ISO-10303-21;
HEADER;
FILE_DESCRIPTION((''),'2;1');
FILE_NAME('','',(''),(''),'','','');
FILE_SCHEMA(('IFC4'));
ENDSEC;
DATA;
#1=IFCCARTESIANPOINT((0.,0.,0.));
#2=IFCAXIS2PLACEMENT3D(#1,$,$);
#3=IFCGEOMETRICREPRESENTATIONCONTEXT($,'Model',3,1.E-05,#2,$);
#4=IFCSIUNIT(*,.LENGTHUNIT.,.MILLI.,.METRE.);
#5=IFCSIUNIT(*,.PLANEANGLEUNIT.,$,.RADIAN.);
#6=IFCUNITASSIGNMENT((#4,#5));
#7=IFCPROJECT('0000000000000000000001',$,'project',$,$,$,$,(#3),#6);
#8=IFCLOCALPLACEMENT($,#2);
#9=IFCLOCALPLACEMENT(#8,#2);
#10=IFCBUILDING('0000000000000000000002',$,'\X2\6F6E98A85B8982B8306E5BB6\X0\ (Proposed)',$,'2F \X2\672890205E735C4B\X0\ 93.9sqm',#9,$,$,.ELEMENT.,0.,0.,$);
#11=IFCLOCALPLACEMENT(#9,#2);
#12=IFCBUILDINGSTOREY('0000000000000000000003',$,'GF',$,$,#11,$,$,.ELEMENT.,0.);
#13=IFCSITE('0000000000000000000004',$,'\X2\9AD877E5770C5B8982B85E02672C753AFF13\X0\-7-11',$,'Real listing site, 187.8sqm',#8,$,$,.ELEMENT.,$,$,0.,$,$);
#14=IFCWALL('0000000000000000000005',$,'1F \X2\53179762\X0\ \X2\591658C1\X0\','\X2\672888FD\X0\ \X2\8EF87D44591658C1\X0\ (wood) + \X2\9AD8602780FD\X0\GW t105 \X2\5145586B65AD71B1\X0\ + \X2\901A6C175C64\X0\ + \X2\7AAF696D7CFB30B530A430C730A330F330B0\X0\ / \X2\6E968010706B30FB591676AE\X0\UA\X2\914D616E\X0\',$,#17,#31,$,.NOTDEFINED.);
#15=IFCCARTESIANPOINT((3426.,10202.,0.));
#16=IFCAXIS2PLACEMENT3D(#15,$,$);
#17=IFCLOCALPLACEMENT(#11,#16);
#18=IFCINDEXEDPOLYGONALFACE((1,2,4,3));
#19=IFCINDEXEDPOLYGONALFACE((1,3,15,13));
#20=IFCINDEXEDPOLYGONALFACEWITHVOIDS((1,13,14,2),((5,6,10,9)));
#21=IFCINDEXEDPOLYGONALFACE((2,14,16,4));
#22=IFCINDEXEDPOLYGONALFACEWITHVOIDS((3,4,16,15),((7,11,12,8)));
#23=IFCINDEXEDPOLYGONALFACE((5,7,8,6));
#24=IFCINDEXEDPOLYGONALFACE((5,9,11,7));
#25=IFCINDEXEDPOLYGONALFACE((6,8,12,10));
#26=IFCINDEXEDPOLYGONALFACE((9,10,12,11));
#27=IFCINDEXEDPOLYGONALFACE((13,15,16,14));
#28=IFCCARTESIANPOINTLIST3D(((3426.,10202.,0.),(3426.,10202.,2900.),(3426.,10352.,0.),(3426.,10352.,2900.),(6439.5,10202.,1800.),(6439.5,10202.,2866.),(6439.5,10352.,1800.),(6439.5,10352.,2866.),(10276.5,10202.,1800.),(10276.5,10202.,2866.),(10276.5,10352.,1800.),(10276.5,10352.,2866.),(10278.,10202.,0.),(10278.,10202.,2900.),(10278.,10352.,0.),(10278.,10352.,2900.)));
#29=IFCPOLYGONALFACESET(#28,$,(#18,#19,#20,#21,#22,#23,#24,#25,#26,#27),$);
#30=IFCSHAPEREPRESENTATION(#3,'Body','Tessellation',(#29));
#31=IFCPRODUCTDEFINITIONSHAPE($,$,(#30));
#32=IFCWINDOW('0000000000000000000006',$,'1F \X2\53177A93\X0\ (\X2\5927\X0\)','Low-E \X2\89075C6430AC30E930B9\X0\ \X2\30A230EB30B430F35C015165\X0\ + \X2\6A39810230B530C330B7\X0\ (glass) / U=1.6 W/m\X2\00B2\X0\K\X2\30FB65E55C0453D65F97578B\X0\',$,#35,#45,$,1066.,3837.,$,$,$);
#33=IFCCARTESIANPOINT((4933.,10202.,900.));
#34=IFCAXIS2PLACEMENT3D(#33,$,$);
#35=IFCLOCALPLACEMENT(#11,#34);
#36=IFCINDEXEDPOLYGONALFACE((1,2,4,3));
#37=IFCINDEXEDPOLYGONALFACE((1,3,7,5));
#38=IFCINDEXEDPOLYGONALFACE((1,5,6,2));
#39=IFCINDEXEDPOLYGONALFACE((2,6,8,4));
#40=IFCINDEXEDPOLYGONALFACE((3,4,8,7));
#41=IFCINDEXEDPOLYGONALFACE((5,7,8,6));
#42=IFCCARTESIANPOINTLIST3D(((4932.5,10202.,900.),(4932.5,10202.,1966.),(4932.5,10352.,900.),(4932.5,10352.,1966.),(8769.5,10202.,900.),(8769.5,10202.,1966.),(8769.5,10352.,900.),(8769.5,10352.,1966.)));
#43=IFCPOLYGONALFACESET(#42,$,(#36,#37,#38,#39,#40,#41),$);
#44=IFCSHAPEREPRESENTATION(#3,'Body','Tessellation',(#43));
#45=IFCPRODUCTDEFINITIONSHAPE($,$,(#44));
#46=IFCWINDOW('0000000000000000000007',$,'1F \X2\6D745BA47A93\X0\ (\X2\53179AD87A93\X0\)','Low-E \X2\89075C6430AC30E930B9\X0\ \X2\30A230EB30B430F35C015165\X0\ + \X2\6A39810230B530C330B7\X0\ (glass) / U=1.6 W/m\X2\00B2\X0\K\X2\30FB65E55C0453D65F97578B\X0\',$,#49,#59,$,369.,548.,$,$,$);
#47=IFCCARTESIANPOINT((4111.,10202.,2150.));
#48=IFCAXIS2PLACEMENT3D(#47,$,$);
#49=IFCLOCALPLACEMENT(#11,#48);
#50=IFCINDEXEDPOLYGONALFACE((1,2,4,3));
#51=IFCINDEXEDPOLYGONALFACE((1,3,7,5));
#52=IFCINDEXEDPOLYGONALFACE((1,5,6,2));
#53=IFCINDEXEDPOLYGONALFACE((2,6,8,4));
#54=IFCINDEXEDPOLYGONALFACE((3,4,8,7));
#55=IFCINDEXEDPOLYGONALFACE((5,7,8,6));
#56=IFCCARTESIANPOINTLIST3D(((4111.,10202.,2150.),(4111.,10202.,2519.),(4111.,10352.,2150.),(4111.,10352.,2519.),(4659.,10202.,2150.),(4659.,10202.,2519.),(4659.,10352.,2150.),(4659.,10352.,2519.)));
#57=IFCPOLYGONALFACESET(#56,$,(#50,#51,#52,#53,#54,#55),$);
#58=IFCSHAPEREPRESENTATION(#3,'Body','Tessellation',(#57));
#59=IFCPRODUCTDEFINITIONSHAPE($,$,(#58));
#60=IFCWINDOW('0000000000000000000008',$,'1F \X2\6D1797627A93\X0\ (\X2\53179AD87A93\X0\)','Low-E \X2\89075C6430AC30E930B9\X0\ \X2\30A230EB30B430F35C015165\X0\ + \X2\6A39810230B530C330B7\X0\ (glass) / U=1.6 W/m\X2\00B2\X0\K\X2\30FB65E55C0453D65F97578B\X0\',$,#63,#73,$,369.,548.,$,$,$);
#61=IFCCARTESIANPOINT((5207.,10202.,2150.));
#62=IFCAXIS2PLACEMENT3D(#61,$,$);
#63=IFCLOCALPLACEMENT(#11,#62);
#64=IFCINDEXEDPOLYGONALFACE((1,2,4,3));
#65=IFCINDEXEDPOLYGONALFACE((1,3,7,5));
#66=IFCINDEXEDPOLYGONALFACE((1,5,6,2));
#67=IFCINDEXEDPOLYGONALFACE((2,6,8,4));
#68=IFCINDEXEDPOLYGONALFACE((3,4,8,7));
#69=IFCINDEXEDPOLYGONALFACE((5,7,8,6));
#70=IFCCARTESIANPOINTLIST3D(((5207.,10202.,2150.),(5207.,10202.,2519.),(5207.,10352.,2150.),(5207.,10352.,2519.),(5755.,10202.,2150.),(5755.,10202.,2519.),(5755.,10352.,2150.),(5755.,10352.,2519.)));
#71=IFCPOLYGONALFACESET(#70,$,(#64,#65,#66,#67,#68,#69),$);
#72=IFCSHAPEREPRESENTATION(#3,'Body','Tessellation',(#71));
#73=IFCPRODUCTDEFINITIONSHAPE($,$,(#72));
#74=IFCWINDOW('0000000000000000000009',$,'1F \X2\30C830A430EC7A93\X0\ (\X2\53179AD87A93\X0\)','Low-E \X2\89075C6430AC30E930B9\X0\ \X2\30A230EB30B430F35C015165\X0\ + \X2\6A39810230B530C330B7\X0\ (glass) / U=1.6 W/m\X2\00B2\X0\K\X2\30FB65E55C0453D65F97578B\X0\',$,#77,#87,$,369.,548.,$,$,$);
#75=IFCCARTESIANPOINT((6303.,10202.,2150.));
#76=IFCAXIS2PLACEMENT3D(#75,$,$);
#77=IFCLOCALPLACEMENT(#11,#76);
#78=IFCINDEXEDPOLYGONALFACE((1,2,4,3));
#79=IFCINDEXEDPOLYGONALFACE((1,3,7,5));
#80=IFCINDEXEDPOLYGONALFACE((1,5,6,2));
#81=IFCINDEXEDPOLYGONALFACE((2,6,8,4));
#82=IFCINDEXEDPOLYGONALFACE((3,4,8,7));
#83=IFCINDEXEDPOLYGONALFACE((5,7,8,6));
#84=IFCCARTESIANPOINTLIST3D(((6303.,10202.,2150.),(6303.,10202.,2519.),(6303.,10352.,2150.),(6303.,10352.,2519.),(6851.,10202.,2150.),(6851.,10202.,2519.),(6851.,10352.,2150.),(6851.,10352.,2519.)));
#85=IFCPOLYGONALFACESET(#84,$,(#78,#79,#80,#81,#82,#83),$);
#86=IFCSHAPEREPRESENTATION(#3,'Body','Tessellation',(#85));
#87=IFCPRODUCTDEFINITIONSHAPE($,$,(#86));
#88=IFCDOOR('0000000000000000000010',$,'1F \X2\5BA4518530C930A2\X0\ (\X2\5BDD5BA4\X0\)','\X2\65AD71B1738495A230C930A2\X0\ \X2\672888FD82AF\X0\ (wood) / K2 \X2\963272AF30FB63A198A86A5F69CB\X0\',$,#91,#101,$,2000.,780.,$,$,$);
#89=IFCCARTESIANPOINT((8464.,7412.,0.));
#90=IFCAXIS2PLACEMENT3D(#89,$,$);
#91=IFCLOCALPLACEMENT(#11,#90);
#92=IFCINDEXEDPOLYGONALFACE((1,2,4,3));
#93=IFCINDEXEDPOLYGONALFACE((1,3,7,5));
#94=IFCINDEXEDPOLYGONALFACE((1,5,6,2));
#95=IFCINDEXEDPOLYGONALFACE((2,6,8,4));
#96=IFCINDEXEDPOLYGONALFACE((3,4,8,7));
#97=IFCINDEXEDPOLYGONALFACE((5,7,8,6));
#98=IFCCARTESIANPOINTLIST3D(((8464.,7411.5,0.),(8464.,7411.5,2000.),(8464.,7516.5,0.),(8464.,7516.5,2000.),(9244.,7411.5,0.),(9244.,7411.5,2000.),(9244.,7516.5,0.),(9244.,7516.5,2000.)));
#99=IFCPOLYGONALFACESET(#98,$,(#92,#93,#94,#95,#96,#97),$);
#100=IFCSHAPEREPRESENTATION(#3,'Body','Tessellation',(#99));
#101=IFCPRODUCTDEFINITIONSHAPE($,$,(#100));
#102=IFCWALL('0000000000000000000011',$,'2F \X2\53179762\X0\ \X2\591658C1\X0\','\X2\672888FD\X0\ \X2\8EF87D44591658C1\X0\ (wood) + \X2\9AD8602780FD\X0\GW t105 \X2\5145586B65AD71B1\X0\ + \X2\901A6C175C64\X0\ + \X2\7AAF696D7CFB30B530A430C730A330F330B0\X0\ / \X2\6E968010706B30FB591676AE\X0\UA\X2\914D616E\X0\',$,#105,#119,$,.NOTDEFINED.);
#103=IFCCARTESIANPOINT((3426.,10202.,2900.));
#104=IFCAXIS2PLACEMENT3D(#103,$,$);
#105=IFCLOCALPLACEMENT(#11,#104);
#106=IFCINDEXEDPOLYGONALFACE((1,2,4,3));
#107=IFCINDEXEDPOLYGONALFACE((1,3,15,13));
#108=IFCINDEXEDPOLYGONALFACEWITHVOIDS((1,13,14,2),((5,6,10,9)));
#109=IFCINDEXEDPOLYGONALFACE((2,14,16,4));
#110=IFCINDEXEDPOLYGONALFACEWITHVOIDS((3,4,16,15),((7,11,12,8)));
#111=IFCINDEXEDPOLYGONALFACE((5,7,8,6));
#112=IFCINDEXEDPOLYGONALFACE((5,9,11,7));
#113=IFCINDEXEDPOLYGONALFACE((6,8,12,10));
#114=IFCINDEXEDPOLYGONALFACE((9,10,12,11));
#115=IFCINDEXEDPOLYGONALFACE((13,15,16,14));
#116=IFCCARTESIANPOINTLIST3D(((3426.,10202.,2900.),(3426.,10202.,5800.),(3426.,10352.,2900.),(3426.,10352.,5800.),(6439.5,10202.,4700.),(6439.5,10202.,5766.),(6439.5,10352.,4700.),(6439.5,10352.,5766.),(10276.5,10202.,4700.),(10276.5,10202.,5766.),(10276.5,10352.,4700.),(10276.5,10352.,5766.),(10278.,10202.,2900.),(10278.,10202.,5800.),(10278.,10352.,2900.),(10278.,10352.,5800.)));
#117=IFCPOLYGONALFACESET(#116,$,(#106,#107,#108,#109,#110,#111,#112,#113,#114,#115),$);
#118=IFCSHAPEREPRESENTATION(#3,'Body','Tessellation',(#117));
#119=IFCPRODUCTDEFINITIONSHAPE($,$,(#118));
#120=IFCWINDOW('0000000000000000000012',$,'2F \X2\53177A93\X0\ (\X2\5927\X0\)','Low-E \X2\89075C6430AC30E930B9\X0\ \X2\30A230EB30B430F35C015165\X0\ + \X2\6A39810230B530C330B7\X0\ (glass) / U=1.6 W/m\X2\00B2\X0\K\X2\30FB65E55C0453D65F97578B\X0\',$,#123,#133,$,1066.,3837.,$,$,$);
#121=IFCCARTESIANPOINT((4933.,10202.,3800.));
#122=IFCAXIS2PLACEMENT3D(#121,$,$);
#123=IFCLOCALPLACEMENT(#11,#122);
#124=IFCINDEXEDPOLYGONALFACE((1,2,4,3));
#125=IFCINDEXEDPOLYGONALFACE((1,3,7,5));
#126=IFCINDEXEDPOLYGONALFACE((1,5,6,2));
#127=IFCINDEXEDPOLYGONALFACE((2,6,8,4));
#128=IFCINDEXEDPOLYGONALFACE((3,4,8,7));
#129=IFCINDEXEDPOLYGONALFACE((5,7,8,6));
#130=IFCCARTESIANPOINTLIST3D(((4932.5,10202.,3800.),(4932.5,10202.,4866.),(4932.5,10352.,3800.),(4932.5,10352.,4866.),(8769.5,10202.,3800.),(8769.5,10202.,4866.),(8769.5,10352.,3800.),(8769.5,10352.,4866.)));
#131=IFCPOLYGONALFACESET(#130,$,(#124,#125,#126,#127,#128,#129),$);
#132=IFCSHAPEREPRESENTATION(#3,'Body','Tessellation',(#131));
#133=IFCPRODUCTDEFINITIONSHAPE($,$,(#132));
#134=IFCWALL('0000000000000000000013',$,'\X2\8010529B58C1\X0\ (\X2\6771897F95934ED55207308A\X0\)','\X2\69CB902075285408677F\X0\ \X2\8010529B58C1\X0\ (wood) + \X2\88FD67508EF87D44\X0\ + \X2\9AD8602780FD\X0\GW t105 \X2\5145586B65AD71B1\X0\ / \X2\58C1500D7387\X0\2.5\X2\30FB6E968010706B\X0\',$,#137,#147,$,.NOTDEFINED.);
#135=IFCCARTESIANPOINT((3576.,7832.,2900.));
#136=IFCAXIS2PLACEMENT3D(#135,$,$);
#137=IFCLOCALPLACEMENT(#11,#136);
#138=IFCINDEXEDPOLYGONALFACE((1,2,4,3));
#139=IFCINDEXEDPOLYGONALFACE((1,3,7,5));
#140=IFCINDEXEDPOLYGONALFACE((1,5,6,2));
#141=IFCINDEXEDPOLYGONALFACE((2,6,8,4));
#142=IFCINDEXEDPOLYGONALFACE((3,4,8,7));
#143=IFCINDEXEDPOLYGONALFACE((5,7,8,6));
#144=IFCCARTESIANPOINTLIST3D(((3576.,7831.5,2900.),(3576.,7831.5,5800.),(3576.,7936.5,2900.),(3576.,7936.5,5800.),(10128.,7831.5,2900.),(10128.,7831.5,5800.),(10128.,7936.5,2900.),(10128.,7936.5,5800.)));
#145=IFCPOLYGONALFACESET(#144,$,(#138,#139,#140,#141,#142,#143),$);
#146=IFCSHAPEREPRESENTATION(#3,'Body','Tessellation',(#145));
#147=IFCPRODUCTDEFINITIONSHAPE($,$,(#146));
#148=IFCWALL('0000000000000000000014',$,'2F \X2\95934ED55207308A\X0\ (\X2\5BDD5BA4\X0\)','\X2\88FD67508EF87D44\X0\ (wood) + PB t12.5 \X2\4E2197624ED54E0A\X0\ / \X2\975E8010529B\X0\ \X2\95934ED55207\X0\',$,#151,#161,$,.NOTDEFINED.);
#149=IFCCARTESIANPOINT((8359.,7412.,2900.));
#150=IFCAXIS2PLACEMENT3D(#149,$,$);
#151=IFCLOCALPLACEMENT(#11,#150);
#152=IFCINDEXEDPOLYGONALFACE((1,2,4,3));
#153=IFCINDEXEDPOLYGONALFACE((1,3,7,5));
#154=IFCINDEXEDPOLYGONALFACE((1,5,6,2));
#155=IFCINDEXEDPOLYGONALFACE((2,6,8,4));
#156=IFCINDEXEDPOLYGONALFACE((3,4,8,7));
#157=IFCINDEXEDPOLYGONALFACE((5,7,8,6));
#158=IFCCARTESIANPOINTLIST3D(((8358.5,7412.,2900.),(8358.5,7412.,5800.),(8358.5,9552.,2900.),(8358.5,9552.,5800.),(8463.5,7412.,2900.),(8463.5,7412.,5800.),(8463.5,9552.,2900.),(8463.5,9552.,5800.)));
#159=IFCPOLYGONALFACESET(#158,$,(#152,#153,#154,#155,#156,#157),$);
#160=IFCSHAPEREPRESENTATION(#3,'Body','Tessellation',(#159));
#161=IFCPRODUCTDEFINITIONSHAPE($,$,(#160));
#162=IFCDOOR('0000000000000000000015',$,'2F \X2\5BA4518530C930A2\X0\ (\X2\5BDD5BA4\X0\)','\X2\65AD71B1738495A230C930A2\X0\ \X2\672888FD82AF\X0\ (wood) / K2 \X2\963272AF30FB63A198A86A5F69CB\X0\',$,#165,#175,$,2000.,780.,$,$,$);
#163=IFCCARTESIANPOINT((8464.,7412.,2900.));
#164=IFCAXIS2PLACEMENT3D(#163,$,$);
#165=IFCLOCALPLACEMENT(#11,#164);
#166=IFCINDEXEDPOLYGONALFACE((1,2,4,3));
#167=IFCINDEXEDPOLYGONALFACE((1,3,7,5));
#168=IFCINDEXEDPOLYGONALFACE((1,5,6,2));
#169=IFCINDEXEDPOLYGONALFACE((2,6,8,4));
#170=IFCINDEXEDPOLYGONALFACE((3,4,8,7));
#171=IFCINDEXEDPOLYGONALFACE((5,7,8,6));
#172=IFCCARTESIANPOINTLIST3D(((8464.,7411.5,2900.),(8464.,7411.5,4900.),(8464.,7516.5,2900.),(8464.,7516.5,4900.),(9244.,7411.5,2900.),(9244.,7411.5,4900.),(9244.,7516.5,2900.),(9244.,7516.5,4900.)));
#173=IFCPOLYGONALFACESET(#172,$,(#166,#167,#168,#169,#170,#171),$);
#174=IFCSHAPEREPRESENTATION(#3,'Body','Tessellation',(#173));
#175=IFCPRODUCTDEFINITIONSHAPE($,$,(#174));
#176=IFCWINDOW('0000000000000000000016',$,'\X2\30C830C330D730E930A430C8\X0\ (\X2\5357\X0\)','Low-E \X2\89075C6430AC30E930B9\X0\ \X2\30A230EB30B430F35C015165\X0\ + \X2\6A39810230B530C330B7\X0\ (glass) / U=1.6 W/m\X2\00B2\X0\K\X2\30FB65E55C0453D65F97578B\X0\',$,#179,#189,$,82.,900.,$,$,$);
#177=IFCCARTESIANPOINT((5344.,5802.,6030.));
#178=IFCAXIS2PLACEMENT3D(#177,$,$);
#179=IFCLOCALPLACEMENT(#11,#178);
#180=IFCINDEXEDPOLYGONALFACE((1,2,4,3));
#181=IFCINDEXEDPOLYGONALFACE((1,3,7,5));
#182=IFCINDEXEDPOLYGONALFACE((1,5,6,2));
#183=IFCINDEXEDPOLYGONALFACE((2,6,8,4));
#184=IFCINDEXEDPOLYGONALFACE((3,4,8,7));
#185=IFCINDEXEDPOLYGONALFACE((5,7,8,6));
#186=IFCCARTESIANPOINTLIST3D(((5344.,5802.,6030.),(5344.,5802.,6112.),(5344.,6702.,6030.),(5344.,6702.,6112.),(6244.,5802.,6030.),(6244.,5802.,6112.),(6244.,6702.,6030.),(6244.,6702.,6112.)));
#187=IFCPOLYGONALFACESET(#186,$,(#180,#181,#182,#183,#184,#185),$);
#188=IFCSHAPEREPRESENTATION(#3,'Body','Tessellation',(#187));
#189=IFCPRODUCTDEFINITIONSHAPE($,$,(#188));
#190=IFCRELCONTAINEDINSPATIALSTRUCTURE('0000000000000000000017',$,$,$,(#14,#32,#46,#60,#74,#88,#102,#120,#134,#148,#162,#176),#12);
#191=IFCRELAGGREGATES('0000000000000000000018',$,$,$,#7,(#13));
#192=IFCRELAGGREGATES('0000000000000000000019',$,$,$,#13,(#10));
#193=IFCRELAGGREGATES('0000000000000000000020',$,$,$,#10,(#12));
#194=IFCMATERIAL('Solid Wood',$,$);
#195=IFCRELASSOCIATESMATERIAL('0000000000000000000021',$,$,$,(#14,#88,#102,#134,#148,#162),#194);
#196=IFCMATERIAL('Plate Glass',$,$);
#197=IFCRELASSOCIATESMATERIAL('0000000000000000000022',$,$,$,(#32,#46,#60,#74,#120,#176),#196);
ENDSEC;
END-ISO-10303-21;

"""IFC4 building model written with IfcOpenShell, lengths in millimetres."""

from ifc_helpers import new_model, si_unit, frame, frame_2d, origin, place, context, project, spatial, rectangle, extrude, material, element, fill, save


model = new_model("IFC4")

# Units and contexts
model_context = context("Model", 3, precision=1e-05, world=origin())
ifc_project = project(units=[si_unit("LENGTHUNIT", "METRE", prefix="MILLI"), si_unit("PLANEANGLEUNIT", "RADIAN")], contexts=[model_context])

# Site, building, storey
site_placement = place(None, origin())
site = spatial("IfcSite", under=ifc_project, at=site_placement, Name="高知県安芸市本町３-7-11", ObjectType="Real listing site, 187.8sqm", CompositionType="ELEMENT", RefElevation=0.0)
building_placement = place(site_placement, origin())
building = spatial("IfcBuilding", under=site, at=building_placement, Name="潮風安芸の家 (Proposed)", ObjectType="2F 木造平屋 93.9sqm", CompositionType="ELEMENT", ElevationOfRefHeight=0.0, ElevationOfTerrain=0.0)
storey_placement = place(building_placement, origin())
storey = spatial("IfcBuildingStorey", under=building, at=storey_placement, Name="GF", CompositionType="ELEMENT", Elevation=0.0)

# Wall, openings, windows
ifc_material_1 = material(Name="Solid Wood")
wall_1_placement = place(storey_placement, frame((3426.0, 10202.0, 0.0)))
wall_1 = element("IfcWall", 1, at=wall_1_placement, inside=storey, material=ifc_material_1, Name="1F 北面 外壁", Description="木製 軸組外壁 (wood) + 高性能GW t105 充填断熱 + 通気層 + 窯業系サイディング / 準耐火・外皮UA配慮", PredefinedType="NOTDEFINED", context=model_context, shape_type="SweptSolid", body=[
    extrude(rectangle(XDim=6852.0, YDim=150.0, at=frame_2d((3426.0, 75.0))), frame((3426.0, 10202.0, 0.0)), (0.0, 0.0, 1.0), 2900.0),
])
opening_1_placement = place(storey_placement, frame((4933.0, 10202.0, 900.0)))
opening_1 = element("IfcOpeningElement", 2, at=opening_1_placement, cuts=wall_1, PredefinedType="NOTDEFINED", context=model_context, shape_type="SweptSolid", body=[
    extrude(rectangle(XDim=3837.0, YDim=150.0, at=frame_2d((1918.0, 75.0))), frame((4933.0, 10202.0, 900.0)), (0.0, 0.0, 1.0), 1066.0),
])
opening_2_placement = place(storey_placement, frame((4111.0, 10202.0, 2150.0)))
opening_2 = element("IfcOpeningElement", 3, at=opening_2_placement, cuts=wall_1, PredefinedType="NOTDEFINED", context=model_context, shape_type="SweptSolid", body=[
    extrude(rectangle(XDim=548.0, YDim=150.0, at=frame_2d((274.0, 75.0))), frame((4111.0, 10202.0, 2150.0)), (0.0, 0.0, 1.0), 369.0),
])
opening_3_placement = place(storey_placement, frame((5207.0, 10202.0, 2150.0)))
opening_3 = element("IfcOpeningElement", 4, at=opening_3_placement, cuts=wall_1, PredefinedType="NOTDEFINED", context=model_context, shape_type="SweptSolid", body=[
    extrude(rectangle(XDim=548.0, YDim=150.0, at=frame_2d((274.0, 75.0))), frame((5207.0, 10202.0, 2150.0)), (0.0, 0.0, 1.0), 369.0),
])
opening_4_placement = place(storey_placement, frame((6303.0, 10202.0, 2150.0)))
opening_4 = element("IfcOpeningElement", 5, at=opening_4_placement, cuts=wall_1, PredefinedType="NOTDEFINED", context=model_context, shape_type="SweptSolid", body=[
    extrude(rectangle(XDim=548.0, YDim=150.0, at=frame_2d((274.0, 75.0))), frame((6303.0, 10202.0, 2150.0)), (0.0, 0.0, 1.0), 369.0),
])
ifc_material_2 = material(Name="Plate Glass")
window_1_placement = place(storey_placement, frame((4933.0, 10202.0, 900.0)))
window_1 = element("IfcWindow", 6, at=window_1_placement, inside=storey, material=ifc_material_2, Name="1F 北窓 (大)", Description="Low-E 複層ガラス アルゴン封入 + 樹脂サッシ (glass) / U=1.6 W/m²K・日射取得型", OverallHeight=1066.0, OverallWidth=3837.0, context=model_context, shape_type="SweptSolid", body=[
    extrude(rectangle(XDim=3837.0, YDim=150.0, at=frame_2d((1918.0, 75.0))), frame((4933.0, 10202.0, 900.0)), (0.0, 0.0, 1.0), 1066.0),
])
fill(opening_1, window_1)
window_2_placement = place(storey_placement, frame((4111.0, 10202.0, 2150.0)))
window_2 = element("IfcWindow", 7, at=window_2_placement, inside=storey, material=ifc_material_2, Name="1F 浴室窓 (北高窓)", Description="Low-E 複層ガラス アルゴン封入 + 樹脂サッシ (glass) / U=1.6 W/m²K・日射取得型", OverallHeight=369.0, OverallWidth=548.0, context=model_context, shape_type="SweptSolid", body=[
    extrude(rectangle(XDim=548.0, YDim=150.0, at=frame_2d((274.0, 75.0))), frame((4111.0, 10202.0, 2150.0)), (0.0, 0.0, 1.0), 369.0),
])
fill(opening_2, window_2)
window_3_placement = place(storey_placement, frame((5207.0, 10202.0, 2150.0)))
window_3 = element("IfcWindow", 8, at=window_3_placement, inside=storey, material=ifc_material_2, Name="1F 洗面窓 (北高窓)", Description="Low-E 複層ガラス アルゴン封入 + 樹脂サッシ (glass) / U=1.6 W/m²K・日射取得型", OverallHeight=369.0, OverallWidth=548.0, context=model_context, shape_type="SweptSolid", body=[
    extrude(rectangle(XDim=548.0, YDim=150.0, at=frame_2d((274.0, 75.0))), frame((5207.0, 10202.0, 2150.0)), (0.0, 0.0, 1.0), 369.0),
])
fill(opening_3, window_3)
window_4_placement = place(storey_placement, frame((6303.0, 10202.0, 2150.0)))
window_4 = element("IfcWindow", 9, at=window_4_placement, inside=storey, material=ifc_material_2, Name="1F トイレ窓 (北高窓)", Description="Low-E 複層ガラス アルゴン封入 + 樹脂サッシ (glass) / U=1.6 W/m²K・日射取得型", OverallHeight=369.0, OverallWidth=548.0, context=model_context, shape_type="SweptSolid", body=[
    extrude(rectangle(XDim=548.0, YDim=150.0, at=frame_2d((274.0, 75.0))), frame((6303.0, 10202.0, 2150.0)), (0.0, 0.0, 1.0), 369.0),
])
fill(opening_4, window_4)

# Door
door_1_placement = place(storey_placement, frame((8464.0, 7412.0, 0.0)))
element("IfcDoor", 10, at=door_1_placement, inside=storey, material=ifc_material_1, Name="1F 室内ドア (寝室)", Description="断熱玄関ドア 木製芯 (wood) / K2 防犯・採風機構", OverallHeight=2000.0, OverallWidth=780.0, context=model_context, shape_type="SweptSolid", body=[
    extrude(rectangle(XDim=780.0, YDim=105.0, at=frame_2d((390.0, 52.0))), frame((8464.0, 7412.0, 0.0)), (0.0, 0.0, 1.0), 2000.0),
])

# Wall, opening, window
wall_2_placement = place(storey_placement, frame((3426.0, 10202.0, 2900.0)))
wall_2 = element("IfcWall", 11, at=wall_2_placement, inside=storey, material=ifc_material_1, Name="2F 北面 外壁", Description="木製 軸組外壁 (wood) + 高性能GW t105 充填断熱 + 通気層 + 窯業系サイディング / 準耐火・外皮UA配慮", PredefinedType="NOTDEFINED", context=model_context, shape_type="SweptSolid", body=[
    extrude(rectangle(XDim=6852.0, YDim=150.0, at=frame_2d((3426.0, 75.0))), frame((3426.0, 10202.0, 2900.0)), (0.0, 0.0, 1.0), 2900.0),
])
opening_5_placement = place(storey_placement, frame((4933.0, 10202.0, 3800.0)))
opening_5 = element("IfcOpeningElement", 12, at=opening_5_placement, cuts=wall_2, PredefinedType="NOTDEFINED", context=model_context, shape_type="SweptSolid", body=[
    extrude(rectangle(XDim=3837.0, YDim=150.0, at=frame_2d((1918.0, 75.0))), frame((4933.0, 10202.0, 3800.0)), (0.0, 0.0, 1.0), 1066.0),
])
window_5_placement = place(storey_placement, frame((4933.0, 10202.0, 3800.0)))
window_5 = element("IfcWindow", 13, at=window_5_placement, inside=storey, material=ifc_material_2, Name="2F 北窓 (大)", Description="Low-E 複層ガラス アルゴン封入 + 樹脂サッシ (glass) / U=1.6 W/m²K・日射取得型", OverallHeight=1066.0, OverallWidth=3837.0, context=model_context, shape_type="SweptSolid", body=[
    extrude(rectangle(XDim=3837.0, YDim=150.0, at=frame_2d((1918.0, 75.0))), frame((4933.0, 10202.0, 3800.0)), (0.0, 0.0, 1.0), 1066.0),
])
fill(opening_5, window_5)

# Walls
wall_3_placement = place(storey_placement, frame((3576.0, 7832.0, 2900.0)))
element("IfcWall", 14, at=wall_3_placement, inside=storey, material=ifc_material_1, Name="耐力壁 (東西間仕切り)", Description="構造用合板 耐力壁 (wood) + 製材軸組 + 高性能GW t105 充填断熱 / 壁倍率2.5・準耐火", PredefinedType="NOTDEFINED", context=model_context, shape_type="SweptSolid", body=[
    extrude(rectangle(XDim=6552.0, YDim=105.0, at=frame_2d((3276.0, 52.0))), frame((3576.0, 7832.0, 2900.0)), (0.0, 0.0, 1.0), 2900.0),
])
wall_4_placement = place(storey_placement, frame((8359.0, 7412.0, 2900.0)))
element("IfcWall", 15, at=wall_4_placement, inside=storey, material=ifc_material_1, Name="2F 間仕切り (寝室)", Description="製材軸組 (wood) + PB t12.5 両面仕上 / 非耐力 間仕切", PredefinedType="NOTDEFINED", context=model_context, shape_type="SweptSolid", body=[
    extrude(rectangle(XDim=105.0, YDim=2140.0, at=frame_2d((52.0, 1070.0))), frame((8359.0, 7412.0, 2900.0)), (0.0, 0.0, 1.0), 2900.0),
])

# Door
door_2_placement = place(storey_placement, frame((8464.0, 7412.0, 2900.0)))
element("IfcDoor", 16, at=door_2_placement, inside=storey, material=ifc_material_1, Name="2F 室内ドア (寝室)", Description="断熱玄関ドア 木製芯 (wood) / K2 防犯・採風機構", OverallHeight=2000.0, OverallWidth=780.0, context=model_context, shape_type="SweptSolid", body=[
    extrude(rectangle(XDim=780.0, YDim=105.0, at=frame_2d((390.0, 52.0))), frame((8464.0, 7412.0, 2900.0)), (0.0, 0.0, 1.0), 2000.0),
])

# Window
window_6_placement = place(storey_placement, frame((5344.0, 5802.0, 6030.0)))
element("IfcWindow", 17, at=window_6_placement, inside=storey, material=ifc_material_2, Name="トップライト (南)", Description="Low-E 複層ガラス アルゴン封入 + 樹脂サッシ (glass) / U=1.6 W/m²K・日射取得型", OverallHeight=82.0, OverallWidth=900.0, context=model_context, shape_type="SweptSolid", body=[
    extrude(rectangle(XDim=900.0, YDim=900.0, at=frame_2d((450.0, 450.0))), frame((5344.0, 5802.0, 6030.0)), (0.0, 0.0, 1.0), 82.0),
])

save(model, "model.ifc")
